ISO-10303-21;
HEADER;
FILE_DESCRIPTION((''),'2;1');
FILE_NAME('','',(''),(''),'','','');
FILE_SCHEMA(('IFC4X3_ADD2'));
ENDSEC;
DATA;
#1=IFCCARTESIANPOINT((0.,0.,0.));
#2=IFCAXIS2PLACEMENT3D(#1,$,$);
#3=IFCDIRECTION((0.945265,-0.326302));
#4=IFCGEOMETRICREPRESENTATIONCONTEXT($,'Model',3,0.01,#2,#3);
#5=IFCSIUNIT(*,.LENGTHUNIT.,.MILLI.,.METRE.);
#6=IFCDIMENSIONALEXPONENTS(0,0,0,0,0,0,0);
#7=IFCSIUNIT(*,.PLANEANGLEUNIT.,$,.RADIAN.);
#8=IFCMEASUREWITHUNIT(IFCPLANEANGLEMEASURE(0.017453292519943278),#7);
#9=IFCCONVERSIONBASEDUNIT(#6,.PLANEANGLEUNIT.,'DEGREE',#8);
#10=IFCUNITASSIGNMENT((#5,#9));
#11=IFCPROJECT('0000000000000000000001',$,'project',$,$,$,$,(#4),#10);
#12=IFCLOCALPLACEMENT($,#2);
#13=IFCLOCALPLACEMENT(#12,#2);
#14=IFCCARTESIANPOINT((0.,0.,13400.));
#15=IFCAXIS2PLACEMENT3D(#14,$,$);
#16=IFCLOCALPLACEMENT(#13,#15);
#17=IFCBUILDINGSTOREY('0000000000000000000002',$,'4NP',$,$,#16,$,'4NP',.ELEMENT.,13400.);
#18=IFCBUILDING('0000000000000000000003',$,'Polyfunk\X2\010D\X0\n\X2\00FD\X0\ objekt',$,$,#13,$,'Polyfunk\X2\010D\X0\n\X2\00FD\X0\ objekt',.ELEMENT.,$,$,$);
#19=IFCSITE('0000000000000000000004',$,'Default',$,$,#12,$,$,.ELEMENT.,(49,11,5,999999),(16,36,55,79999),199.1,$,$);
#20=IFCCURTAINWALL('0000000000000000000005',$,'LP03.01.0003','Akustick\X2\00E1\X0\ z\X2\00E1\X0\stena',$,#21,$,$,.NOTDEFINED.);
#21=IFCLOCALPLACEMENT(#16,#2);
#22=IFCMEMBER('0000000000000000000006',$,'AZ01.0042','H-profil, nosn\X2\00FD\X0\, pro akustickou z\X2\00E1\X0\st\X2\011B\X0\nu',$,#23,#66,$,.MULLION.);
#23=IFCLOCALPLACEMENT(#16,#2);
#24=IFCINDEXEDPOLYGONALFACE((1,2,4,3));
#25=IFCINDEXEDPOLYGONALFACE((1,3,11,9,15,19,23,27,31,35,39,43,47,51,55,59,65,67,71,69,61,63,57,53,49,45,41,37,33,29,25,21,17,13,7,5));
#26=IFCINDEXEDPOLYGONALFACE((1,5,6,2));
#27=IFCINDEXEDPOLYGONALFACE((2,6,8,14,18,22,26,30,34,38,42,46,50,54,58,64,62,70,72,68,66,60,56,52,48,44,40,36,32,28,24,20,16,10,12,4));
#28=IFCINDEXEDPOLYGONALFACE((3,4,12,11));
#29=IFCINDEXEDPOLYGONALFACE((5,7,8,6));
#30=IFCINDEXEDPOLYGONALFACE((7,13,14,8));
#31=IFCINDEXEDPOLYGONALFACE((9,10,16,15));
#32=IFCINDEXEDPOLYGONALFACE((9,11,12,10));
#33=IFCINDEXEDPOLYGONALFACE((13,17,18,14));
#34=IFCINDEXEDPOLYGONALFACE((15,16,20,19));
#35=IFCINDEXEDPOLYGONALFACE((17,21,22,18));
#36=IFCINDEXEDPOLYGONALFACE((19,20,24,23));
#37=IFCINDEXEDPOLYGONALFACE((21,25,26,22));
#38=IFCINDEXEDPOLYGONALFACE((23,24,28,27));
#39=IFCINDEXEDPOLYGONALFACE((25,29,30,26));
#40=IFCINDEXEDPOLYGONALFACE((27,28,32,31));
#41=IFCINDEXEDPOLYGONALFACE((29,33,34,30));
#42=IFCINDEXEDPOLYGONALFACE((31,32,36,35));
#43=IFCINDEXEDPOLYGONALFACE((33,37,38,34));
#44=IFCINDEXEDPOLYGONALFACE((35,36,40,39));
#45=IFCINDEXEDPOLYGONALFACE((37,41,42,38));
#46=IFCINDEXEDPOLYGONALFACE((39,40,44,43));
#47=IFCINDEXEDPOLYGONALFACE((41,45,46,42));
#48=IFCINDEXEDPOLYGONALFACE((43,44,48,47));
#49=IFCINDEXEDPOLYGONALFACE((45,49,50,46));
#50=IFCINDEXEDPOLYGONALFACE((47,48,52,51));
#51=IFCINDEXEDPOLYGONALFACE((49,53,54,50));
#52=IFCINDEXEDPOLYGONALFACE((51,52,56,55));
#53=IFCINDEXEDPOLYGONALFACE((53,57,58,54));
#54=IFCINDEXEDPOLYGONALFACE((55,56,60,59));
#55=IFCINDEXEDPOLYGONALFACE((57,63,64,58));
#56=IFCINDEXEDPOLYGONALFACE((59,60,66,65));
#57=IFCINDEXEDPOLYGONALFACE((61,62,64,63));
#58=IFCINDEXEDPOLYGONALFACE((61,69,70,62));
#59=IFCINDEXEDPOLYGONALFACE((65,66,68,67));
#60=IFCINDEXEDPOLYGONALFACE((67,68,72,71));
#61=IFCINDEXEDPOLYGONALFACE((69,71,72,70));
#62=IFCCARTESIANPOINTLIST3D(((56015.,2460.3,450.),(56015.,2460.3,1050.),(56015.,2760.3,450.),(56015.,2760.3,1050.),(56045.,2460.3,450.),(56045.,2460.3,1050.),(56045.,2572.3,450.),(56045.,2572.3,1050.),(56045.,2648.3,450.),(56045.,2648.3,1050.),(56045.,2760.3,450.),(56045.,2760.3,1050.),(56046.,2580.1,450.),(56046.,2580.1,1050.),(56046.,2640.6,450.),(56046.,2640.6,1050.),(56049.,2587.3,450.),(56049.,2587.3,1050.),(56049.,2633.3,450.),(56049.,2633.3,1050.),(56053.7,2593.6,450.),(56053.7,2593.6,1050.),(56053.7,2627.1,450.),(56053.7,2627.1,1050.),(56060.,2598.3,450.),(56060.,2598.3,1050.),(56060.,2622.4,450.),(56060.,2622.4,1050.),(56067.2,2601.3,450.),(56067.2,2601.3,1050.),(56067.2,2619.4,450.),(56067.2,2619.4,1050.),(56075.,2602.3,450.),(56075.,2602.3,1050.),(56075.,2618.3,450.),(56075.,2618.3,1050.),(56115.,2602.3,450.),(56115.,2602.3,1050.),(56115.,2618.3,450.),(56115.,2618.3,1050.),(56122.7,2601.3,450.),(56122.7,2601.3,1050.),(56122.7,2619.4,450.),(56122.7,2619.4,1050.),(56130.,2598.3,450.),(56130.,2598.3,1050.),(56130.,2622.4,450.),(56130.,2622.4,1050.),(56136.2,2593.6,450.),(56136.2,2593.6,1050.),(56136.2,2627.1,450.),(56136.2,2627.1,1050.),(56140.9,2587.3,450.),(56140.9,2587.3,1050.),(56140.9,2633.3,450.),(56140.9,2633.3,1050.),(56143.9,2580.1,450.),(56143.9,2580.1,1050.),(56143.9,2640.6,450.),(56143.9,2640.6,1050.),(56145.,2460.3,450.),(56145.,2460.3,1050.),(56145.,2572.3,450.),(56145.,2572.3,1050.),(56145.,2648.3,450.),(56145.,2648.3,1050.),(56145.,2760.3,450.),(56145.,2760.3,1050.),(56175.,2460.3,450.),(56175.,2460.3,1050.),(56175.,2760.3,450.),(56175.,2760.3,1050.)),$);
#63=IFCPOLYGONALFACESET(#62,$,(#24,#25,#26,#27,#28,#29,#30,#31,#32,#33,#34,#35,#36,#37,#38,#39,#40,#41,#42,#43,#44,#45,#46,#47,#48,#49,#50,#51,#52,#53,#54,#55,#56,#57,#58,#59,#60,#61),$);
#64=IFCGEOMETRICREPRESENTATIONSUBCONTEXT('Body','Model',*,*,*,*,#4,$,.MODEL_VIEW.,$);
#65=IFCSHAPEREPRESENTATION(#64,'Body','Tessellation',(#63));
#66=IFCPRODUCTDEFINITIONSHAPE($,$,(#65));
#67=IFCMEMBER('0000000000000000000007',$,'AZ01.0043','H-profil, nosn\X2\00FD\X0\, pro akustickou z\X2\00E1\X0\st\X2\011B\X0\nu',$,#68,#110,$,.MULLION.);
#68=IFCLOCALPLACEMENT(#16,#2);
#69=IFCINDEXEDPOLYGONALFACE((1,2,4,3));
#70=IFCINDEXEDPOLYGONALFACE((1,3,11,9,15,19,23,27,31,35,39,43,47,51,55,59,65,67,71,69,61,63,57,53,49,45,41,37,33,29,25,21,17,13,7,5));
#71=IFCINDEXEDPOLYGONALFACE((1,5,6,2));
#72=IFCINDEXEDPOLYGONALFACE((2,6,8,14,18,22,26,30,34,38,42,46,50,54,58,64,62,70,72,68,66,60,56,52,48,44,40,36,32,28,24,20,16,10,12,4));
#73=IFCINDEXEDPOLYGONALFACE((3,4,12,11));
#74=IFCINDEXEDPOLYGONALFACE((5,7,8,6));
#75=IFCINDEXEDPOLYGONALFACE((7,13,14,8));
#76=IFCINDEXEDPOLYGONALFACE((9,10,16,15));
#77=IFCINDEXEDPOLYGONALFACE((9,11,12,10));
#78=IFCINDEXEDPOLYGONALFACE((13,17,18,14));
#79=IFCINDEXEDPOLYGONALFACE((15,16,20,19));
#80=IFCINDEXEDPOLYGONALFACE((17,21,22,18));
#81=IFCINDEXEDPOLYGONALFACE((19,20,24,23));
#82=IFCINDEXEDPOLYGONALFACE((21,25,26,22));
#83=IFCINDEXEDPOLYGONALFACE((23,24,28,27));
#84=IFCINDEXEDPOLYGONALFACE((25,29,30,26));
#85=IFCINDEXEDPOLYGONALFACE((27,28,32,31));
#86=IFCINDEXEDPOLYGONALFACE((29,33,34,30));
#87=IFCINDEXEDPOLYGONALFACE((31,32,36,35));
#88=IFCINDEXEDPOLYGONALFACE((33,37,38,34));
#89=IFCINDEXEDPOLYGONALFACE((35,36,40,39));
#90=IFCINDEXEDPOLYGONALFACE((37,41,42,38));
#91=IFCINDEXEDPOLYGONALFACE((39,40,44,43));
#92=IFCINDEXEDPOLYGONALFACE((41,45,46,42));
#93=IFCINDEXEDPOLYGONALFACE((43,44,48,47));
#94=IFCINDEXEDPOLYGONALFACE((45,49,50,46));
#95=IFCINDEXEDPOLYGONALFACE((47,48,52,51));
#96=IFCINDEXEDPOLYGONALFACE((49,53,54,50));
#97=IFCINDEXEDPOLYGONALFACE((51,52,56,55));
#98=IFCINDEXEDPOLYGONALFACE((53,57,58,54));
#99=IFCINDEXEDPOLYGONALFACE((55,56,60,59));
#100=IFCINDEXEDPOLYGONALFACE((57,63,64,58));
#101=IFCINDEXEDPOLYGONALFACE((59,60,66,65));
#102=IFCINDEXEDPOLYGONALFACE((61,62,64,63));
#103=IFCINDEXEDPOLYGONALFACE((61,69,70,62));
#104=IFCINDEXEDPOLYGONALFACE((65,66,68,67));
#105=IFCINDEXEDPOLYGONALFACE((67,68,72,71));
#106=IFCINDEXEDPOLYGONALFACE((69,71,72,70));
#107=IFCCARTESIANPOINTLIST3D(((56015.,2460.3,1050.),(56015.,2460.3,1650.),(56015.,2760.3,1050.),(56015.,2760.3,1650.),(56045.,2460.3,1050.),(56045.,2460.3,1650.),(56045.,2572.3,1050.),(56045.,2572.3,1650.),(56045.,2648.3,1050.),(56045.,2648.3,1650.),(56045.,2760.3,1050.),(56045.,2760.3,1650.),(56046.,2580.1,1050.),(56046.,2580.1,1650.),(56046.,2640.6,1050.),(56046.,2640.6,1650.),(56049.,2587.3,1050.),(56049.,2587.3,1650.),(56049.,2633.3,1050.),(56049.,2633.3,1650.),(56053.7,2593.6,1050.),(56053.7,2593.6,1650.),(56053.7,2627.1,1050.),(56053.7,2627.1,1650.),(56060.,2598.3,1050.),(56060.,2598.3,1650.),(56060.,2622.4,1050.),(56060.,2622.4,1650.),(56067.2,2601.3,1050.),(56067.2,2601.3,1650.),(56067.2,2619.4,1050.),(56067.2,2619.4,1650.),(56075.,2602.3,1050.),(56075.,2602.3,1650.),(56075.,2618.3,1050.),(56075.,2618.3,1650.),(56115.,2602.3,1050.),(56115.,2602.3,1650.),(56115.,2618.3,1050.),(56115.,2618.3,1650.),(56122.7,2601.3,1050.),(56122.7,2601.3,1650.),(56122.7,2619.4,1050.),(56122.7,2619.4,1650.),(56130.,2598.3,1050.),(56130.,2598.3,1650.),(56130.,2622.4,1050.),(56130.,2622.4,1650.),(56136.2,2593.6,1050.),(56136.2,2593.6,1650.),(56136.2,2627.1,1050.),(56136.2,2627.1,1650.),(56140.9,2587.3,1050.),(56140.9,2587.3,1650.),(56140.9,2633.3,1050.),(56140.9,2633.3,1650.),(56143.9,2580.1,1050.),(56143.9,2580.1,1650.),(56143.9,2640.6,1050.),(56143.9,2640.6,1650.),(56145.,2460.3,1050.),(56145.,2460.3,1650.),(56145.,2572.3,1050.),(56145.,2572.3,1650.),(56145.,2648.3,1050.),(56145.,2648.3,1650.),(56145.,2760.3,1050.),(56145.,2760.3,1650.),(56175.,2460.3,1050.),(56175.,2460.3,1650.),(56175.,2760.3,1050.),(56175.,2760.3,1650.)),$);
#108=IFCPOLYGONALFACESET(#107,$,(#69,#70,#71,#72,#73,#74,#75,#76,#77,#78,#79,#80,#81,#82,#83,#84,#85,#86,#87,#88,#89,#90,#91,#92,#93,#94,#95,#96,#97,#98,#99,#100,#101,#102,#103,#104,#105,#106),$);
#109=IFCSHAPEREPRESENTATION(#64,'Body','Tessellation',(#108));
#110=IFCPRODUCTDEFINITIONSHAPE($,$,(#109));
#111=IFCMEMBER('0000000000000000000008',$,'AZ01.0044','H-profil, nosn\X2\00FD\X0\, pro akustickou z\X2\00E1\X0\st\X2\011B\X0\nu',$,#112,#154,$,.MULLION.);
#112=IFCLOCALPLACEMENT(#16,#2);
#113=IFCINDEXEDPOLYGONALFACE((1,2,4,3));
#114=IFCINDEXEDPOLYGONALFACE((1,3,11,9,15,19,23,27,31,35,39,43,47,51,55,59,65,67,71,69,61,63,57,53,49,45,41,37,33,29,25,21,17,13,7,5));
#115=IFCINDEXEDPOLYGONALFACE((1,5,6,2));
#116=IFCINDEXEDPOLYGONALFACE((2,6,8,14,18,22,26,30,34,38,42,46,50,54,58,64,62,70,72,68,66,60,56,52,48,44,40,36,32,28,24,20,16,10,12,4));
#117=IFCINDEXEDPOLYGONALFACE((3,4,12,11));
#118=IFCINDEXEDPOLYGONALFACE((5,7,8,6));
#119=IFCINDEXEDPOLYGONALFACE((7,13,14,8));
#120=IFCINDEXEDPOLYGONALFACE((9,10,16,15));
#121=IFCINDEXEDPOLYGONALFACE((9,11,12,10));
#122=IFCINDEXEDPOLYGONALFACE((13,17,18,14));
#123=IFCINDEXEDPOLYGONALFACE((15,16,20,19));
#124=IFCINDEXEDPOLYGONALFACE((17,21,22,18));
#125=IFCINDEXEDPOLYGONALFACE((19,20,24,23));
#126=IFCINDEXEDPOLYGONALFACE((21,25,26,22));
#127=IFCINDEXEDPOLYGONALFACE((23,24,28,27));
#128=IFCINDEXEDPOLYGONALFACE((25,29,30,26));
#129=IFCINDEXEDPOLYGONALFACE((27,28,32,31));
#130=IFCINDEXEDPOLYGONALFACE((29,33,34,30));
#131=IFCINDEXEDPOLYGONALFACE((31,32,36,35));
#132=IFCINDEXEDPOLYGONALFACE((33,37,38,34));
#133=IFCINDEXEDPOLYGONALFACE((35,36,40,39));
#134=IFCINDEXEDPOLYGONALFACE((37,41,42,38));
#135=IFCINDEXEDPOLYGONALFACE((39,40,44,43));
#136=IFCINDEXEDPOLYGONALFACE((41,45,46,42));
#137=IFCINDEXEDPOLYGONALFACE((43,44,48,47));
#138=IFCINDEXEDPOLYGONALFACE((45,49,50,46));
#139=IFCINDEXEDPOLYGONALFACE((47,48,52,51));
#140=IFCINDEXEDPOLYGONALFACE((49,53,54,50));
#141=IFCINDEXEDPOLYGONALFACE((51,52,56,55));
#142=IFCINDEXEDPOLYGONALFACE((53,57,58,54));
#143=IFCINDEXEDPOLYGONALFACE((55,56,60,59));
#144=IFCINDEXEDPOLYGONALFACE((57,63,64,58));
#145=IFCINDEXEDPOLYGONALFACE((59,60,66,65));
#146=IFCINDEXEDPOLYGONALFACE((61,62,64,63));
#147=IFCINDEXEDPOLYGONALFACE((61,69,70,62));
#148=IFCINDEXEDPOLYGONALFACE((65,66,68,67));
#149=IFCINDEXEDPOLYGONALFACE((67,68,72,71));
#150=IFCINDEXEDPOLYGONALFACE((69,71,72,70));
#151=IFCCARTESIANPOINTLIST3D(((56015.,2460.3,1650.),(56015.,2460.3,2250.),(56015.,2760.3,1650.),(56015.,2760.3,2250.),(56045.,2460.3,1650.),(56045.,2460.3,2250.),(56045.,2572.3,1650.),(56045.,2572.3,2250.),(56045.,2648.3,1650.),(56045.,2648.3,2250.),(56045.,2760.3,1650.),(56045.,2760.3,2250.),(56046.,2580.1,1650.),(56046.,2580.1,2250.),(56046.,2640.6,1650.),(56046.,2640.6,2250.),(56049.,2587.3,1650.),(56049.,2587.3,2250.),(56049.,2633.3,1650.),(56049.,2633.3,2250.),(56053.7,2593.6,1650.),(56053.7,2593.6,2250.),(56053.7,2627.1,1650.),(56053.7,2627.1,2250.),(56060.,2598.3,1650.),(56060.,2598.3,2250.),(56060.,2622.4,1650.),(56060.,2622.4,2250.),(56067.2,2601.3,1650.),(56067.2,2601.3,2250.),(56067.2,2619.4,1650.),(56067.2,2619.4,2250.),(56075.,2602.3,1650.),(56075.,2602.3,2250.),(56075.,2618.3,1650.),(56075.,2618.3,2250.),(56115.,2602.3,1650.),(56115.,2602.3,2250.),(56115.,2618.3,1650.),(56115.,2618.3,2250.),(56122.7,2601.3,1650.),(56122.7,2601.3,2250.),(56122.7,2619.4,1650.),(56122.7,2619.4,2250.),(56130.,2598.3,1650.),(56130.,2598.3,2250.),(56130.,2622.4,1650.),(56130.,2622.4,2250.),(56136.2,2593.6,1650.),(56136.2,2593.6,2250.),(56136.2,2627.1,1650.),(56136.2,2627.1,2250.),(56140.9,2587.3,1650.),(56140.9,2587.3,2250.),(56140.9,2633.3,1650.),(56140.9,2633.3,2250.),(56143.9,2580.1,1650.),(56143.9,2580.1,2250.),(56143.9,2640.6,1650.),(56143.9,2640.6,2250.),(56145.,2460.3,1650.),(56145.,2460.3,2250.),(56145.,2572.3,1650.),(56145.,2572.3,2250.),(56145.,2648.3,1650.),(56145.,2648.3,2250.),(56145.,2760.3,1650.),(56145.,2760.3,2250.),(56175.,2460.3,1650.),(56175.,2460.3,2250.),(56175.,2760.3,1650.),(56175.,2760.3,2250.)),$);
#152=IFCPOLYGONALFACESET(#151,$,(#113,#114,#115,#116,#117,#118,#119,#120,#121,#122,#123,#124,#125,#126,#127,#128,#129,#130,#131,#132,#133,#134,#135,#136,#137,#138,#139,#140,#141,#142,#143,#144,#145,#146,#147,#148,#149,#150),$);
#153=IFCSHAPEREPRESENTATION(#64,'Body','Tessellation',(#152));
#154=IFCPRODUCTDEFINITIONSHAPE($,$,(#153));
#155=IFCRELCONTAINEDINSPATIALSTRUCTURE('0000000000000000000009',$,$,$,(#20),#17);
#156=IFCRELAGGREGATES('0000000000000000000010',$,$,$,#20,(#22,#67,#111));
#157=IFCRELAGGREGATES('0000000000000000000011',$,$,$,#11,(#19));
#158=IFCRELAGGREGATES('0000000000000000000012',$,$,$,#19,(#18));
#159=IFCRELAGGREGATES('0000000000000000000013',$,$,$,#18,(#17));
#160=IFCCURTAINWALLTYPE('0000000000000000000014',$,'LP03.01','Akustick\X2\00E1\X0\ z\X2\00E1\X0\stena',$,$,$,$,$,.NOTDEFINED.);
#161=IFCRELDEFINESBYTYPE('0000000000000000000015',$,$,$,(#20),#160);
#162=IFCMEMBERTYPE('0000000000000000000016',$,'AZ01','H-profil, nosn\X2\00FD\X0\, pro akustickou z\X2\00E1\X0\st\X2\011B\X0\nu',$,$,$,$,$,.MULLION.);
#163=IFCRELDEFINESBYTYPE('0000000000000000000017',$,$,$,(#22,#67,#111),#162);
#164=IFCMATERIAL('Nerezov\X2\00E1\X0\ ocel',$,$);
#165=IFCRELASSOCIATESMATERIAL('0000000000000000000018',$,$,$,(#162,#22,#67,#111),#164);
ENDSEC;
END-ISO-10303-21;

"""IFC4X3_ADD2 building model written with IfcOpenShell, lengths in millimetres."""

from ifc_helpers import new_model, entity, si_unit, converted_unit, direction, frame, frame_2d, origin, place, context, subcontext, project, spatial, polyline, circle_curve, parameter, trimmed, segment, composite_curve, outline, extrude, source, transform, mapped, material, material_profile, profile_set, profile_usage, type_object, element, aggregate, save


model = new_model("IFC4X3_ADD2")

# Units and contexts
model_context = context("Model", 3, precision=0.01, world=origin(), true_north=direction((0.945265, -0.326302)))
body_context = subcontext(model_context, "Body", "Model", "MODEL_VIEW")
ifc_project = project(units=[si_unit("LENGTHUNIT", "METRE", prefix="MILLI"), converted_unit("PLANEANGLEUNIT", "DEGREE", entity("IfcPlaneAngleMeasure", 0.017453292519943278), si_unit("PLANEANGLEUNIT", "RADIAN"), dimensions=[0, 0, 0, 0, 0, 0, 0])], contexts=[model_context])

# Site, building, storey
site_placement = place(None, origin())
site = spatial("IfcSite", under=ifc_project, at=site_placement, Name="Default", CompositionType="ELEMENT", RefLatitude=(49, 11, 5, 999999), RefLongitude=(16, 36, 55, 79999), RefElevation=199.1)
building_placement = place(site_placement, origin())
building = spatial("IfcBuilding", under=site, at=building_placement, Name="Polyfunkčný objekt", LongName="Polyfunkčný objekt", CompositionType="ELEMENT")
storey_placement = place(building_placement, frame((0.0, 0.0, 13400.0)))
storey = spatial("IfcBuildingStorey", under=building, at=storey_placement, Name="4NP", LongName="4NP", CompositionType="ELEMENT", Elevation=13400.0)

# Curtain wall, members
curtain_wall_type = type_object("IfcCurtainWallType", Name="LP03.01", Description="Akustická zástena", PredefinedType="NOTDEFINED")
curtain_wall_placement = place(storey_placement, frame((0.0, 0.0, -13400.0)))
curtain_wall = element("IfcCurtainWall", 1, at=curtain_wall_placement, inside=storey, type_object=curtain_wall_type, Name="LP03.01.0003", Description="Akustická zástena", PredefinedType="NOTDEFINED")
ifc_material_1 = material(Name="Nerezová ocel")
ifc_material_profile = material_profile(ifc_material_1, outline(composite_curve([segment(polyline([(50.0, -150.0), (80.0, -150.0)]), True, "CONTINUOUS"), segment(polyline([(80.0, -150.0), (80.0, 150.0)]), True, "CONTINUOUS"), segment(polyline([(80.0, 150.0), (50.0, 150.0)]), True, "CONTINUOUS"), segment(polyline([(50.0, 150.0), (50.0, 38.0)]), True, "CONTINUOUS"), segment(trimmed(circle_curve(frame_2d((20.0, 38.0), x_axis=(0.0, 1.0)), 30.0), [parameter(180.0)], [parameter(270.0)], True, "PARAMETER"), False, "CONTINUOUS"), segment(polyline([(20.0, 8.0), (-20.0, 8.0)]), True, "CONTINUOUS"), segment(trimmed(circle_curve(frame_2d((-20.0, 38.0), x_axis=(0.0, 1.0)), 30.0), [parameter(90.0)], [parameter(180.0)], True, "PARAMETER"), False, "CONTINUOUS"), segment(polyline([(-50.0, 38.0), (-50.0, 150.0)]), True, "CONTINUOUS"), segment(polyline([(-50.0, 150.0), (-80.0, 150.0)]), True, "CONTINUOUS"), segment(polyline([(-80.0, 150.0), (-80.0, -150.0)]), True, "CONTINUOUS"), segment(polyline([(-80.0, -150.0), (-50.0, -150.0)]), True, "CONTINUOUS"), segment(polyline([(-50.0, -150.0), (-50.0, -38.0)]), True, "CONTINUOUS"), segment(trimmed(circle_curve(frame_2d((-20.0, -38.0), x_axis=(0.0, 1.0)), 30.0), [parameter(0.0)], [parameter(90.0)], True, "PARAMETER"), False, "CONTINUOUS"), segment(polyline([(-20.0, -8.0), (20.0, -8.0)]), True, "CONTINUOUS"), segment(trimmed(circle_curve(frame_2d((20.0, -38.0), x_axis=(0.0, 1.0)), 30.0), [parameter(270.0)], [parameter(0.0)], True, "PARAMETER"), False, "CONTINUOUS"), segment(polyline([(50.0, -38.0), (50.0, -150.0)]), True, "CONTINUOUS")], self_intersect=False)), Name="Profil zástena")
ifc_profile_set = profile_set([ifc_material_profile], Name="Profil zástena")
ifc_profile_usage = profile_usage(ifc_profile_set)
member_type = type_object("IfcMemberType", Name="AZ01", Description="H-profil, nosný, pro akustickou zástěnu", PredefinedType="MULLION", material=ifc_profile_set)
shared_shape_1 = source(origin(), body_context, "Body", "SweptSolid", [
    extrude(outline(composite_curve([segment(polyline([(-150.0, -50.0), (-150.0, -80.0)]), True, "CONTINUOUS"), segment(polyline([(-150.0, -80.0), (150.0, -80.0)]), True, "CONTINUOUS"), segment(polyline([(150.0, -80.0), (150.0, -50.0)]), True, "CONTINUOUS"), segment(polyline([(150.0, -50.0), (38.0, -50.0)]), True, "CONTINUOUS"), segment(trimmed(circle_curve(frame_2d((38.0, -20.0), x_axis=(1.0, 0.0)), 30.0), [parameter(180.0)], [parameter(270.0)], True, "PARAMETER"), False, "CONTINUOUS"), segment(polyline([(8.0, -20.0), (8.0, 20.0)]), True, "CONTINUOUS"), segment(trimmed(circle_curve(frame_2d((38.0, 20.0), x_axis=(1.0, 0.0)), 30.0), [parameter(90.0)], [parameter(180.0)], True, "PARAMETER"), False, "CONTINUOUS"), segment(polyline([(38.0, 50.0), (150.0, 50.0)]), True, "CONTINUOUS"), segment(polyline([(150.0, 50.0), (150.0, 80.0)]), True, "CONTINUOUS"), segment(polyline([(150.0, 80.0), (-150.0, 80.0)]), True, "CONTINUOUS"), segment(polyline([(-150.0, 80.0), (-150.0, 50.0)]), True, "CONTINUOUS"), segment(polyline([(-150.0, 50.0), (-38.0, 50.0)]), True, "CONTINUOUS"), segment(trimmed(circle_curve(frame_2d((-38.0, 20.0), x_axis=(1.0, 0.0)), 30.0), [parameter(0.0)], [parameter(90.0)], True, "PARAMETER"), False, "CONTINUOUS"), segment(polyline([(-8.0, 20.0), (-8.0, -20.0)]), True, "CONTINUOUS"), segment(trimmed(circle_curve(frame_2d((-38.0, -20.0), x_axis=(1.0, 0.0)), 30.0), [parameter(270.0)], [parameter(0.0)], True, "PARAMETER"), False, "CONTINUOUS"), segment(polyline([(-38.0, -50.0), (-150.0, -50.0)]), True, "CONTINUOUS")], self_intersect=False)), frame((0.0, 0.0, -600.0), z_axis=(0.0, 0.0, -1.0), x_axis=(1.0, 0.0, 0.0)), (0.0, 0.0, -1.0), 600.0),
])
member_1_placement = place(curtain_wall_placement, frame((56095.0, 2610.3, 13850.0), z_axis=(0.0, 0.0, -1.0), x_axis=(0.0, 1.0, 0.0)))
member_1 = element("IfcMember", 2, at=member_1_placement, type_object=member_type, material=ifc_profile_usage, Name="AZ01.0042", Description="H-profil, nosný, pro akustickou zástěnu", PredefinedType="MULLION", context=body_context, shape_type="MappedRepresentation", body=[
    mapped(shared_shape_1, transform((0.0, 0.0, 0.0), scale=1.0)),
])
member_2_placement = place(curtain_wall_placement, frame((56095.0, 2610.3, 14450.0), z_axis=(0.0, 0.0, -1.0), x_axis=(0.0, 1.0, 0.0)))
member_2 = element("IfcMember", 3, at=member_2_placement, type_object=member_type, material=ifc_profile_usage, Name="AZ01.0043", Description="H-profil, nosný, pro akustickou zástěnu", PredefinedType="MULLION", context=body_context, shape_type="MappedRepresentation", body=[
    mapped(shared_shape_1, transform((0.0, 0.0, 0.0), scale=1.0)),
])
member_3_placement = place(curtain_wall_placement, frame((56095.0, 2610.3, 15050.0), z_axis=(0.0, 0.0, -1.0), x_axis=(0.0, 1.0, 0.0)))
member_3 = element("IfcMember", 4, at=member_3_placement, type_object=member_type, material=ifc_profile_usage, Name="AZ01.0044", Description="H-profil, nosný, pro akustickou zástěnu", PredefinedType="MULLION", context=body_context, shape_type="MappedRepresentation", body=[
    mapped(shared_shape_1, transform((0.0, 0.0, 0.0), scale=1.0)),
])
aggregate(curtain_wall, [member_1, member_2, member_3])

save(model, "model.ifc")
